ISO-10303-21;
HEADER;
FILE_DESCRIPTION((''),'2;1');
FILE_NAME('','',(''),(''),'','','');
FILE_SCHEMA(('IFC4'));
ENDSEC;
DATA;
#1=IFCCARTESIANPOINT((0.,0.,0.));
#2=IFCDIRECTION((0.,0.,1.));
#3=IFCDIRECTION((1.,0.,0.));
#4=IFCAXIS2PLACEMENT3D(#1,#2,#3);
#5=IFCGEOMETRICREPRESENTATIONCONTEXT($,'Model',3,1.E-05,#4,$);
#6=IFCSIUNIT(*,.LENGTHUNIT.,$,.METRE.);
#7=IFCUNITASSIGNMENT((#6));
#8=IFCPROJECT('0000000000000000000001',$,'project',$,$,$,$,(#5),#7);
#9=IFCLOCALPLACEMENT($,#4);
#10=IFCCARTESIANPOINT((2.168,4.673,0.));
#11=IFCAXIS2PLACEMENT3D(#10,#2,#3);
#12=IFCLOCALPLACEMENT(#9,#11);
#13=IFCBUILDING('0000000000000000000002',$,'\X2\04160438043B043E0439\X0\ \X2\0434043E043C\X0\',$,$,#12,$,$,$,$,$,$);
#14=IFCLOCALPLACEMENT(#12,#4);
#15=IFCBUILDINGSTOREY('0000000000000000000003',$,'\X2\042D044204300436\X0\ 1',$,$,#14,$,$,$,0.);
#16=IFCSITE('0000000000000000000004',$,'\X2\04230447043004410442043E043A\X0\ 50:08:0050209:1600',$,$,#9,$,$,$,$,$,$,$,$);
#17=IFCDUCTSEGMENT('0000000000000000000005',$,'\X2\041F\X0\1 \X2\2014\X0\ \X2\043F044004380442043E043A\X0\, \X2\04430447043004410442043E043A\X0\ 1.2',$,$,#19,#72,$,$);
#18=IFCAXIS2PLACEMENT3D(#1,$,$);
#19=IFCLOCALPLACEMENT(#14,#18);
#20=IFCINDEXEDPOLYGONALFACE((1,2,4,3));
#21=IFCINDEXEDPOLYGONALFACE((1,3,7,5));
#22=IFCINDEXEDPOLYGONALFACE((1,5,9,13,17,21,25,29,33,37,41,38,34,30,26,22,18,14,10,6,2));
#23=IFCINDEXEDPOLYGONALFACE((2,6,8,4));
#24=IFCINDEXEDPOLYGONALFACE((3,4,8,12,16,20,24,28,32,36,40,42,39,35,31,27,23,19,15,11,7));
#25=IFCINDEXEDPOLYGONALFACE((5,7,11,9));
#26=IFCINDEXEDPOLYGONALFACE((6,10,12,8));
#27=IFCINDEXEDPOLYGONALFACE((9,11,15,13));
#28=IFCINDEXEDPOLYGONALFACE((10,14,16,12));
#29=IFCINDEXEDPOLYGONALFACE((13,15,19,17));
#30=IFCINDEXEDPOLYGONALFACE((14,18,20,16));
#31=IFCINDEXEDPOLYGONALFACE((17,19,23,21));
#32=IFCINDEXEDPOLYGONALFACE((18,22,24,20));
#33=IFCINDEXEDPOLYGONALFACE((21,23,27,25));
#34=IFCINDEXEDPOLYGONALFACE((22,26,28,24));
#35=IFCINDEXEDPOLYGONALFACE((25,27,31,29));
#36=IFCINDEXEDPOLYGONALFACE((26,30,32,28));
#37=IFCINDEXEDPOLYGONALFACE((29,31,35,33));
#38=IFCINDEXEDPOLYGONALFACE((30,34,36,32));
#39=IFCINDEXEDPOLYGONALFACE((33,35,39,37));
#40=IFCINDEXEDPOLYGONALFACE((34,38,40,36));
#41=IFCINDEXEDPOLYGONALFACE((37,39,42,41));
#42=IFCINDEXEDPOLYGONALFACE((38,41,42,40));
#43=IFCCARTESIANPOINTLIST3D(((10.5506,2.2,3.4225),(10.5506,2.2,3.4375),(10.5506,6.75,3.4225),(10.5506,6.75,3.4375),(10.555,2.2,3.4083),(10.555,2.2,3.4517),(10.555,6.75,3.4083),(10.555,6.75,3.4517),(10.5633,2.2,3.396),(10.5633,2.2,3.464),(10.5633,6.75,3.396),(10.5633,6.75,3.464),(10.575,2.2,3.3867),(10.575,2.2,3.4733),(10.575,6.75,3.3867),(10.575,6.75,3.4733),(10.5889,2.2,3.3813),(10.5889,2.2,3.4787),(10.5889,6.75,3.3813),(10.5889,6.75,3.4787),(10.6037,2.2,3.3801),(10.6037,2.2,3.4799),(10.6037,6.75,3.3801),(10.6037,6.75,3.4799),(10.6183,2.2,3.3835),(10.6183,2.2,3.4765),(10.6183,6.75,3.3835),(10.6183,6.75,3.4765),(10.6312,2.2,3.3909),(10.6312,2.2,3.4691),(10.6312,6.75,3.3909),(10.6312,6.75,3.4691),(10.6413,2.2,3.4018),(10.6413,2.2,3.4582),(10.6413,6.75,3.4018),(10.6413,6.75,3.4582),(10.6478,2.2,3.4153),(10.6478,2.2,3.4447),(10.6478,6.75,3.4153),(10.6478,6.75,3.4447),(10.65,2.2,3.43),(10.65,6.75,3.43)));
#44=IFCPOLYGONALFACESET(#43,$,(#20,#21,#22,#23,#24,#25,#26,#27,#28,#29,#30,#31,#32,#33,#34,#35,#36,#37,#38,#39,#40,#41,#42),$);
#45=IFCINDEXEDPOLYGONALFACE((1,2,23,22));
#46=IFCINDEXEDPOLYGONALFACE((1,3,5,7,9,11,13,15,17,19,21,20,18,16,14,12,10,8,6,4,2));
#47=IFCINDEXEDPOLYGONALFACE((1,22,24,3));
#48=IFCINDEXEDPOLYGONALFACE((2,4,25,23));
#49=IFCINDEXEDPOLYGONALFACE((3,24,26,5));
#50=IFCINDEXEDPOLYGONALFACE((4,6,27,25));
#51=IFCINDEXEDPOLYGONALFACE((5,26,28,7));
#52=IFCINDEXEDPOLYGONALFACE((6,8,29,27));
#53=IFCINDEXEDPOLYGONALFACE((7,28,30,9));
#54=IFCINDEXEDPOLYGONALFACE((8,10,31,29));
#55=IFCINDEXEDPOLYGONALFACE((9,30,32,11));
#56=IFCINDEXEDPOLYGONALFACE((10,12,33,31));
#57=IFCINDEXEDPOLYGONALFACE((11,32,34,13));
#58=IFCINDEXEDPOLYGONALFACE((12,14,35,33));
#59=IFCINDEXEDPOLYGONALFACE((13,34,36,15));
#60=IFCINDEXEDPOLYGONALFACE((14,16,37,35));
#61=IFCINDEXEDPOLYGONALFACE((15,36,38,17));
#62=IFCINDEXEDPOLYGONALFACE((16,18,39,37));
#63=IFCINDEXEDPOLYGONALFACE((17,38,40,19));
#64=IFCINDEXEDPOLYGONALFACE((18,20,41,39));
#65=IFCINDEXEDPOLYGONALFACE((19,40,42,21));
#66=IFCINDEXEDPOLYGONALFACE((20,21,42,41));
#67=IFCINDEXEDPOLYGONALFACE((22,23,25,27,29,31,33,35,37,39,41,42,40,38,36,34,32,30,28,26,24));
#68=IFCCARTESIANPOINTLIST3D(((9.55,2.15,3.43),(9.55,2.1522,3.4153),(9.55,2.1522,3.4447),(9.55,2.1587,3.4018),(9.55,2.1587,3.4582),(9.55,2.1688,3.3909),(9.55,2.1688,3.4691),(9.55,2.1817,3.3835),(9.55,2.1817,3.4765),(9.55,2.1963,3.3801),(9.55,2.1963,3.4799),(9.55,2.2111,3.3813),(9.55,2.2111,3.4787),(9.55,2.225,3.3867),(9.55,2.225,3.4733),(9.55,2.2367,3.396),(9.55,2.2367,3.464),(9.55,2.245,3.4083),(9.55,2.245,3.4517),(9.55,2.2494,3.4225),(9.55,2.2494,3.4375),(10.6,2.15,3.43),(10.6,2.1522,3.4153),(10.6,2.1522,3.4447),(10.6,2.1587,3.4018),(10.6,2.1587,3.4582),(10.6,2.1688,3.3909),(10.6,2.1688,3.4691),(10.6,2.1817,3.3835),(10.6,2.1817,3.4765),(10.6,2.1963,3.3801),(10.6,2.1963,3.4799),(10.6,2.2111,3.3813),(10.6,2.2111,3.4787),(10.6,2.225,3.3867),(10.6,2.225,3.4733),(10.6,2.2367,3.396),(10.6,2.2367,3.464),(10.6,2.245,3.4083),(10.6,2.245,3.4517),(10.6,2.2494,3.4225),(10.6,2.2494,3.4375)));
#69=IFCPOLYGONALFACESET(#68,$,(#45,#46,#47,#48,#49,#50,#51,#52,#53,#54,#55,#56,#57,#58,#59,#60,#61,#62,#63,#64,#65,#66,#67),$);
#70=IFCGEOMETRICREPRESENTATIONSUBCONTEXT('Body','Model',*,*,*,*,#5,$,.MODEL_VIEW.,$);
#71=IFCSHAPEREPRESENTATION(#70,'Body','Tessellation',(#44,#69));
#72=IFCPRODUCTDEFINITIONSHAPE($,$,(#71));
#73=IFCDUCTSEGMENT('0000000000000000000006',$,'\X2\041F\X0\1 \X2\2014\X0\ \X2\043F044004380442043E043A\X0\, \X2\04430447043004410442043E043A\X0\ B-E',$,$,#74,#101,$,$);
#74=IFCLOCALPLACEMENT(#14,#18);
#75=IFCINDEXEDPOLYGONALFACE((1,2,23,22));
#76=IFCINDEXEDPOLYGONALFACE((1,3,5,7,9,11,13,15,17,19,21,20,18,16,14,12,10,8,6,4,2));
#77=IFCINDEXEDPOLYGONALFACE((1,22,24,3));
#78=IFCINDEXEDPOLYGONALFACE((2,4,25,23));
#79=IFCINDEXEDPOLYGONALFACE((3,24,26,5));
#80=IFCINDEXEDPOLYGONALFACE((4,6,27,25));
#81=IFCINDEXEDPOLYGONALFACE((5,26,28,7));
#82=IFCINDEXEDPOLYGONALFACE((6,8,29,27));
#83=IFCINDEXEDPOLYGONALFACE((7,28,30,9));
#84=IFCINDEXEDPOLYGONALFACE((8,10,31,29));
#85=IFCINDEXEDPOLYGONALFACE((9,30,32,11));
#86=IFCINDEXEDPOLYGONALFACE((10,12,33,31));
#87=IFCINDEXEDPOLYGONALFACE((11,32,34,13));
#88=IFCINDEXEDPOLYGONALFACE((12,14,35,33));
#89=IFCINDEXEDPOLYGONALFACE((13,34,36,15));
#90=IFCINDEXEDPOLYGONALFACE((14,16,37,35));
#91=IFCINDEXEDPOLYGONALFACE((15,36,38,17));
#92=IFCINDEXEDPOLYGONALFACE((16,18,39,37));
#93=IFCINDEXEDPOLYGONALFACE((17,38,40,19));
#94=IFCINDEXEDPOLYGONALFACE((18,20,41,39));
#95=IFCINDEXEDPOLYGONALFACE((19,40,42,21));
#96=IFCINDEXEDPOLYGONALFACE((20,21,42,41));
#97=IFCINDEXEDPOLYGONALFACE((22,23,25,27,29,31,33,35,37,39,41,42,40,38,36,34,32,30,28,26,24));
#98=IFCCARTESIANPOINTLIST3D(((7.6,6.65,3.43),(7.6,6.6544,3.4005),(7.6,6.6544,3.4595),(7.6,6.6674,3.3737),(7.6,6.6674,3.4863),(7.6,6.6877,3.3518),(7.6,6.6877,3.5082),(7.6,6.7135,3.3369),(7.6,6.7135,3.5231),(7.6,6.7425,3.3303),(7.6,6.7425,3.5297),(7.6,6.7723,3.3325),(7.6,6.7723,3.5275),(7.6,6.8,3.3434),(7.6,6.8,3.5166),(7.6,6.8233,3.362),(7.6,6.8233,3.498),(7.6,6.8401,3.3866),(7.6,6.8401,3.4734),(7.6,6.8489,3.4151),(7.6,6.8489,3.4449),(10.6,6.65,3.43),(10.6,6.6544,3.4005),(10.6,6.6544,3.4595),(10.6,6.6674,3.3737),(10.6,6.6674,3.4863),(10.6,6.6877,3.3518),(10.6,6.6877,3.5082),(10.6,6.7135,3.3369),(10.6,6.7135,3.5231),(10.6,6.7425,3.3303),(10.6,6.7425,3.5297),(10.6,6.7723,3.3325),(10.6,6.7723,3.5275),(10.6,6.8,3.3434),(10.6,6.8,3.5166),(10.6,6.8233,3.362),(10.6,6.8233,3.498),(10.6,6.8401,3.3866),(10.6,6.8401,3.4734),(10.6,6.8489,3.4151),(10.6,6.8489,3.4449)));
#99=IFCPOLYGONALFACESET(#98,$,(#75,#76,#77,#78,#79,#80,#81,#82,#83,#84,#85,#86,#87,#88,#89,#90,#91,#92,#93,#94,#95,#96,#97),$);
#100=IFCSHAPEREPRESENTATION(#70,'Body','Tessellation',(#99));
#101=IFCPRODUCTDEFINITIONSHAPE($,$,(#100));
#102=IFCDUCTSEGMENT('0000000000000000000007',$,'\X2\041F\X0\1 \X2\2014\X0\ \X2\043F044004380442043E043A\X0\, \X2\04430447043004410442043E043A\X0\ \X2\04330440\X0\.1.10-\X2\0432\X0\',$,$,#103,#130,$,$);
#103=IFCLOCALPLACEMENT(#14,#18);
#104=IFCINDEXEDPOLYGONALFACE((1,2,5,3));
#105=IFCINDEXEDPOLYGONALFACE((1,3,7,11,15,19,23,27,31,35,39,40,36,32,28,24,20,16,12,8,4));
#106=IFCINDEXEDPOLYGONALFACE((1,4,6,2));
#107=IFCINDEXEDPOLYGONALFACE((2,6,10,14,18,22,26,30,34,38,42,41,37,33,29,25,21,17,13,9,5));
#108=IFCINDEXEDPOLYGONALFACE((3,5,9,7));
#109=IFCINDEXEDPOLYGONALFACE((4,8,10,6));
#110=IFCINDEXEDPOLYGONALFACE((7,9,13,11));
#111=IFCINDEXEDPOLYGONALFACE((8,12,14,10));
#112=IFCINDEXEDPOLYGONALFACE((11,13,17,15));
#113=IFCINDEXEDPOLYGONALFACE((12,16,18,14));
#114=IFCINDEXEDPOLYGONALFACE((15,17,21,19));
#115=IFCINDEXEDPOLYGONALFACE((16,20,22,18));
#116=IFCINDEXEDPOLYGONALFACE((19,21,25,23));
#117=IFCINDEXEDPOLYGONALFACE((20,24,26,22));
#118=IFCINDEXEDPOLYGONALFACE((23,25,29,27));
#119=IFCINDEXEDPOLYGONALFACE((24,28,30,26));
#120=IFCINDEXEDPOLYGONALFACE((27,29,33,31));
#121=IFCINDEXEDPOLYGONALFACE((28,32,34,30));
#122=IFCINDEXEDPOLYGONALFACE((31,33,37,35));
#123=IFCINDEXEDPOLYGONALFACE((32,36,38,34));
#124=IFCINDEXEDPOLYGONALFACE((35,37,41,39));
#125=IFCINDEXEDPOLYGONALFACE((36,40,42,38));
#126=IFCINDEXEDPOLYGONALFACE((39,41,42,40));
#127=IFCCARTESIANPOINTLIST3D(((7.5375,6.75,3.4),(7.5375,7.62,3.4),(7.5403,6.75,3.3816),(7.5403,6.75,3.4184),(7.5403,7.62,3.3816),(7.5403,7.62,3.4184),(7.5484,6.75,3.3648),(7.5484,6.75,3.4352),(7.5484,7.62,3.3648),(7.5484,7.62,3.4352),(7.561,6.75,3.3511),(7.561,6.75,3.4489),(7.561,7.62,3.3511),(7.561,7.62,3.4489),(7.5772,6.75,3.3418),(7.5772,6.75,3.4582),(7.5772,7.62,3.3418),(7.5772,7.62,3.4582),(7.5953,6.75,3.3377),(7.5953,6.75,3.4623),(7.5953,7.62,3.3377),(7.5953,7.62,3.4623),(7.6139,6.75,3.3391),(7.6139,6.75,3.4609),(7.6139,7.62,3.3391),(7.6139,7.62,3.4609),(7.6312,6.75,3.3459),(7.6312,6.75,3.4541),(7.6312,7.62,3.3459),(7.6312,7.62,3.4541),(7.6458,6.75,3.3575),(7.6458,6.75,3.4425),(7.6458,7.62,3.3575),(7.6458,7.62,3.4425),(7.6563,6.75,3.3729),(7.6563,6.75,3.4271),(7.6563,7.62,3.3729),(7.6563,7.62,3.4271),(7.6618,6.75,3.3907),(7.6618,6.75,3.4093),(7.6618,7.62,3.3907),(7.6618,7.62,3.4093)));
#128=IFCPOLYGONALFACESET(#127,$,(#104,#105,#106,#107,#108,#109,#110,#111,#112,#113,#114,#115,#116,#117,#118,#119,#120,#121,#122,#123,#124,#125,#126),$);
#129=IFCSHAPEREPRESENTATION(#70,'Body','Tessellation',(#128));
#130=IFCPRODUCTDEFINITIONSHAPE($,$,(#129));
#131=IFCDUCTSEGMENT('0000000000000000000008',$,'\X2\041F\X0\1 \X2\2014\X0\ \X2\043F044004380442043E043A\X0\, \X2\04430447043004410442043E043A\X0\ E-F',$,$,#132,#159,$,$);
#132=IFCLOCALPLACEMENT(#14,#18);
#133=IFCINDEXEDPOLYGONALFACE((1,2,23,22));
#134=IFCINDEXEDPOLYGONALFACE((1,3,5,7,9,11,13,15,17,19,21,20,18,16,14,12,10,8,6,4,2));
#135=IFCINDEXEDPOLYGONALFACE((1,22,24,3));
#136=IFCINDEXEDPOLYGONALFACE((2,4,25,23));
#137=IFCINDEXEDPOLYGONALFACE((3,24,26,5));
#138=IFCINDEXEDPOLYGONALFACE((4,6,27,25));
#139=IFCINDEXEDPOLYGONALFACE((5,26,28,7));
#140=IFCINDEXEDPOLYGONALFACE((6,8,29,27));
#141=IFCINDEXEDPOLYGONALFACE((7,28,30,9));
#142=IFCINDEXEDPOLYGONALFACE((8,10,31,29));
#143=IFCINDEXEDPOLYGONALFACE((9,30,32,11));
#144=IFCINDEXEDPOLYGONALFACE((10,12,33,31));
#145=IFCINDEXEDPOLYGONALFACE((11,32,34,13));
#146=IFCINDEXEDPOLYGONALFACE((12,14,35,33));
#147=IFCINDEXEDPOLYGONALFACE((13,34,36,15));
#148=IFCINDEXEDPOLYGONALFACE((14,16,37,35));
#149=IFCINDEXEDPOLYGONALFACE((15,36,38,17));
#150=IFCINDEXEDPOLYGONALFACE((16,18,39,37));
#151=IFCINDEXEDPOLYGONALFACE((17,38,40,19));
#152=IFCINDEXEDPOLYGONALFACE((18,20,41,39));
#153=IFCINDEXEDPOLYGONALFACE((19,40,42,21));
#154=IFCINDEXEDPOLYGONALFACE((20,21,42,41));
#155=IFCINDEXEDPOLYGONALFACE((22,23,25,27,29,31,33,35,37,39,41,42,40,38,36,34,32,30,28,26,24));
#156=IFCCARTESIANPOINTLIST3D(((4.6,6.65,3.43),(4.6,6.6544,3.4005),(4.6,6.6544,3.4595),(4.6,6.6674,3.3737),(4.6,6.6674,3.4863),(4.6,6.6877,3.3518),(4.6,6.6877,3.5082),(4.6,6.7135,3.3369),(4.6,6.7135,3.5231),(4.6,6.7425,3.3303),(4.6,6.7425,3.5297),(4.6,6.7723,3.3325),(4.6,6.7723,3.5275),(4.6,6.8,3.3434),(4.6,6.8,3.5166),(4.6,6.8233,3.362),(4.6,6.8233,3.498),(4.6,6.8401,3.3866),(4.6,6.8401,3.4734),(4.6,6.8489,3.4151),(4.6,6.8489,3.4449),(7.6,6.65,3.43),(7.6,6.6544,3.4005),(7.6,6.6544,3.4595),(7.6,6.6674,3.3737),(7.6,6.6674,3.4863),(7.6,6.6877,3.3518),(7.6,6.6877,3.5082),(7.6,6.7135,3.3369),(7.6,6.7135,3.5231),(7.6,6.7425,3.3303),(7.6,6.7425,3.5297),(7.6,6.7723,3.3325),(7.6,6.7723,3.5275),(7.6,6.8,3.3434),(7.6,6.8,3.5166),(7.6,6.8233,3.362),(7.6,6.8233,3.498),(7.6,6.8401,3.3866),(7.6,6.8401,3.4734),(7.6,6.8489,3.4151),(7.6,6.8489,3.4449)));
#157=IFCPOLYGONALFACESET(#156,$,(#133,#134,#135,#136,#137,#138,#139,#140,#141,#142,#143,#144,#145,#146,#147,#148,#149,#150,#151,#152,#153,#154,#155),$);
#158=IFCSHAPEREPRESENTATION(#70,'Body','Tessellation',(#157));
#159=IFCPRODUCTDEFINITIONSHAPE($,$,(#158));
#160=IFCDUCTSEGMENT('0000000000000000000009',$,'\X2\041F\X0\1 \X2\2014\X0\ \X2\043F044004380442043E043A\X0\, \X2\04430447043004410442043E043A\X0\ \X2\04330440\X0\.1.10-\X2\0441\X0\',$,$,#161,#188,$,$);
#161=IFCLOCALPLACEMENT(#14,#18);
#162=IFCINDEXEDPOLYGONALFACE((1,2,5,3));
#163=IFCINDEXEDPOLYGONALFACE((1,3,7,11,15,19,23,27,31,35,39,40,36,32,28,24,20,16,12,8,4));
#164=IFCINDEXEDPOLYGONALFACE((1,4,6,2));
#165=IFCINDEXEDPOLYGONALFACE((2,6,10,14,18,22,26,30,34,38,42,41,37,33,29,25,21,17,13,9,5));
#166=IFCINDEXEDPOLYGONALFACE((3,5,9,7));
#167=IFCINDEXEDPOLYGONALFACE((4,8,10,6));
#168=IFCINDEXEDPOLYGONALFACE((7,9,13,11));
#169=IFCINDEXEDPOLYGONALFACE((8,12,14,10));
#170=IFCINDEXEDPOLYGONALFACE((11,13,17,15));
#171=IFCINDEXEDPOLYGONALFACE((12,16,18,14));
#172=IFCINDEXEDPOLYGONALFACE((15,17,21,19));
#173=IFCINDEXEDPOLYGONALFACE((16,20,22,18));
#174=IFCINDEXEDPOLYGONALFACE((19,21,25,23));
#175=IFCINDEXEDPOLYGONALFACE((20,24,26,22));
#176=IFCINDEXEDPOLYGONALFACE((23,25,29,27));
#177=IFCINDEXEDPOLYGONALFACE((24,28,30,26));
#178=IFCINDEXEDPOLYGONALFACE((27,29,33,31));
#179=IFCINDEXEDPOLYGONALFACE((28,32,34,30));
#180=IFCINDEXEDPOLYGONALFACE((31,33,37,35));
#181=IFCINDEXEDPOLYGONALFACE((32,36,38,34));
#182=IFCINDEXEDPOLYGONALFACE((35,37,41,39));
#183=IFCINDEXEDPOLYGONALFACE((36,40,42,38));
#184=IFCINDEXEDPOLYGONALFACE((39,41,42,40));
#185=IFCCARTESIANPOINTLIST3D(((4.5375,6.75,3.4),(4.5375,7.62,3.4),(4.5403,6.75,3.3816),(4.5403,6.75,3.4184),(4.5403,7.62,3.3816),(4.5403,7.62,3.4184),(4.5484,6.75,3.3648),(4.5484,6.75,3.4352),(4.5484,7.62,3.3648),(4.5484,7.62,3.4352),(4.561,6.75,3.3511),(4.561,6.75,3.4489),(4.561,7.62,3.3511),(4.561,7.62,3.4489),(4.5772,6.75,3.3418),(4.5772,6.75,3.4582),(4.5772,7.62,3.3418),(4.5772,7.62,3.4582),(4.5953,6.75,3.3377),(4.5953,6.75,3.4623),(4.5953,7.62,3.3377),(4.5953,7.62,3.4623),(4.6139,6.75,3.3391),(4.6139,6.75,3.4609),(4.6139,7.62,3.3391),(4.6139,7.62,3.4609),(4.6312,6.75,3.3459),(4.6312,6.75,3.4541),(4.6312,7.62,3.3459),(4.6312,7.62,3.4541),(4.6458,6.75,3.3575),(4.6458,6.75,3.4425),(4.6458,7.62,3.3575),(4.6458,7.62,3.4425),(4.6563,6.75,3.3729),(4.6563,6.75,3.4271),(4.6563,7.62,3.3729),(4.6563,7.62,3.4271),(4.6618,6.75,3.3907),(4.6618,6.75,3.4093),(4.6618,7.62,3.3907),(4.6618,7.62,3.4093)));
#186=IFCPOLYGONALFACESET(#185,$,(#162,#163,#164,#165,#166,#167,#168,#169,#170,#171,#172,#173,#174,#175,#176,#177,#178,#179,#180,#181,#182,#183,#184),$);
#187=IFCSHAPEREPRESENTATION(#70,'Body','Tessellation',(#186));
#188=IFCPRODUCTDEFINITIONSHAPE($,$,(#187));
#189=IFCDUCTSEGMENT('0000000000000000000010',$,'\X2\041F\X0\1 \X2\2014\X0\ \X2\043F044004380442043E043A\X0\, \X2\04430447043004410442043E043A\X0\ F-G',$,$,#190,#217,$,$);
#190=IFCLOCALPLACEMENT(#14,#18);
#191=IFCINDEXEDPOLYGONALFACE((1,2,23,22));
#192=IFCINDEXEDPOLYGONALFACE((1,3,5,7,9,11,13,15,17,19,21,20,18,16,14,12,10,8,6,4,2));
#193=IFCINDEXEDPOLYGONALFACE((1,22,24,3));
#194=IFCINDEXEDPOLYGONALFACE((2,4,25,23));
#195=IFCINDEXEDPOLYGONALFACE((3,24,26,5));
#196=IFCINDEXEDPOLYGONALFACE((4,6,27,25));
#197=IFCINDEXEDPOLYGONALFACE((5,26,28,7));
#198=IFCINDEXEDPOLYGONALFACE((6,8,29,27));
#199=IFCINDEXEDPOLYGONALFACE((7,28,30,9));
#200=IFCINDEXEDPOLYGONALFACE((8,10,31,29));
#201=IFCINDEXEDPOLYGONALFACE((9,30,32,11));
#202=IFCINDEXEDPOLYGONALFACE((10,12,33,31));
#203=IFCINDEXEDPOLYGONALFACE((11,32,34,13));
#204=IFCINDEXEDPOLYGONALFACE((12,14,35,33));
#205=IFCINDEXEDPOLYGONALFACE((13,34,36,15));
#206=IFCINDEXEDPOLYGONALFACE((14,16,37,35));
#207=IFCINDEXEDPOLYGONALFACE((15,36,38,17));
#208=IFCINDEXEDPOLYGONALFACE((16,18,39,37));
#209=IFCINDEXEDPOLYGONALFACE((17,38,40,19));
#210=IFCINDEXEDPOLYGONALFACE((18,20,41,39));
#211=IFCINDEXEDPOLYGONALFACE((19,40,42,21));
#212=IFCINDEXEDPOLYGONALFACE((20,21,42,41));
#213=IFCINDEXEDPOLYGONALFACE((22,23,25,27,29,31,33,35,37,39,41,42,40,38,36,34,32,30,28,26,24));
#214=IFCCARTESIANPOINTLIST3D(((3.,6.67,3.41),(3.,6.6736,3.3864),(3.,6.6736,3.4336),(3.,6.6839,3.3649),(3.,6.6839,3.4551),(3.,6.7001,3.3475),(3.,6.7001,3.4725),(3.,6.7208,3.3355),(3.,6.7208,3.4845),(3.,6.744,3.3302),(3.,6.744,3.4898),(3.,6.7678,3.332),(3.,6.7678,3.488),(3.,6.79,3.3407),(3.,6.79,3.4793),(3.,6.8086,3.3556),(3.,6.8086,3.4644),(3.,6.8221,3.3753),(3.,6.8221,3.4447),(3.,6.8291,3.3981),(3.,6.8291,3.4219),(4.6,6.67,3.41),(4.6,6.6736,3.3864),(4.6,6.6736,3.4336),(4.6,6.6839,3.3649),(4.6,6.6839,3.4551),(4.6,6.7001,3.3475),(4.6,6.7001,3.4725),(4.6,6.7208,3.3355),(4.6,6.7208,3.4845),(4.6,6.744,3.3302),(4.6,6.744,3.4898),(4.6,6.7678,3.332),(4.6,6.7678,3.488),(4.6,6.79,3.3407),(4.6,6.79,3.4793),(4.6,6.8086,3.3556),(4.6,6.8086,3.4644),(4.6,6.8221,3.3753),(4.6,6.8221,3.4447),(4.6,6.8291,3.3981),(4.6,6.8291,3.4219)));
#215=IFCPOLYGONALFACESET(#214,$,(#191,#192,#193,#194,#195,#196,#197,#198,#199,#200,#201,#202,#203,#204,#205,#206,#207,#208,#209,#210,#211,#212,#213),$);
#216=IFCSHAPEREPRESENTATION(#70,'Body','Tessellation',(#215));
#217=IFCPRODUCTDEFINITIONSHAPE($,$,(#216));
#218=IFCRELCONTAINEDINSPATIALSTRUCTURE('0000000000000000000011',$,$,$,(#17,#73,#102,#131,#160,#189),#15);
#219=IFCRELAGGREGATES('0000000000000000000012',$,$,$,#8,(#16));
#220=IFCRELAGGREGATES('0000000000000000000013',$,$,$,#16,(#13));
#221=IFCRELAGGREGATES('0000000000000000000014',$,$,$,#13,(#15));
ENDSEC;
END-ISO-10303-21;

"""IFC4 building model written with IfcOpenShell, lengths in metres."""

from ifc_helpers import new_model, si_unit, frame, origin_with_axes, origin_2d, place, context, subcontext, project, spatial, circle, extrude, element, save


model = new_model("IFC4")

# Units and contexts
model_context = context("Model", 3, precision=1e-05, world=origin_with_axes())
body_context = subcontext(model_context, "Body", "Model", "MODEL_VIEW")
ifc_project = project(units=[si_unit("LENGTHUNIT", "METRE")], contexts=[model_context])

# Site, building, storey
site_placement = place(None, origin_with_axes())
site = spatial("IfcSite", under=ifc_project, at=site_placement, Name="Участок 50:08:0050209:1600")
building_placement = place(site_placement, frame((2.168, 4.673, 0.0), z_axis=(0.0, 0.0, 1.0), x_axis=(1.0, 0.0, 0.0)))
building = spatial("IfcBuilding", under=site, at=building_placement, Name="Жилой дом")
storey_placement = place(building_placement, origin_with_axes())
storey = spatial("IfcBuildingStorey", under=building, at=storey_placement, Name="Этаж 1", Elevation=0.0)

# Duct segments
duct_segment_1_placement = place(storey_placement, origin_with_axes())
element("IfcDuctSegment", 1, at=duct_segment_1_placement, inside=storey, Name="П1 — приток, участок 1.2", context=body_context, shape_type="SweptSolid", body=[
    extrude(circle(Radius=0.05, at=origin_2d()), frame((10.6, 6.75, 3.43), z_axis=(0.0, -1.0, 0.0), x_axis=(1.0, 0.0, 0.0)), (0.0, 0.0, 1.0), 4.55),
    extrude(circle(Radius=0.05, at=origin_2d()), frame((10.6, 2.2, 3.43), z_axis=(-1.0, 0.0, 0.0), x_axis=(0.0, -1.0, 0.0)), (0.0, 0.0, 1.0), 1.05),
])
duct_segment_2_placement = place(storey_placement, origin_with_axes())
element("IfcDuctSegment", 2, at=duct_segment_2_placement, inside=storey, Name="П1 — приток, участок B-E", context=body_context, shape_type="SweptSolid", body=[
    extrude(circle(Radius=0.1, at=origin_2d()), frame((10.6, 6.75, 3.43), z_axis=(-1.0, 0.0, 0.0), x_axis=(0.0, -1.0, 0.0)), (0.0, 0.0, 1.0), 3.0),
])
duct_segment_3_placement = place(storey_placement, origin_with_axes())
element("IfcDuctSegment", 3, at=duct_segment_3_placement, inside=storey, Name="П1 — приток, участок гр.1.10-в", context=body_context, shape_type="SweptSolid", body=[
    extrude(circle(Radius=0.0625, at=origin_2d()), frame((7.6, 6.75, 3.4), z_axis=(0.0, 1.0, 0.0), x_axis=(-1.0, 0.0, 0.0)), (0.0, 0.0, 1.0), 0.87),
])
duct_segment_4_placement = place(storey_placement, origin_with_axes())
element("IfcDuctSegment", 4, at=duct_segment_4_placement, inside=storey, Name="П1 — приток, участок E-F", context=body_context, shape_type="SweptSolid", body=[
    extrude(circle(Radius=0.1, at=origin_2d()), frame((7.6, 6.75, 3.43), z_axis=(-1.0, 0.0, 0.0), x_axis=(0.0, -1.0, 0.0)), (0.0, 0.0, 1.0), 3.0),
])
duct_segment_5_placement = place(storey_placement, origin_with_axes())
element("IfcDuctSegment", 5, at=duct_segment_5_placement, inside=storey, Name="П1 — приток, участок гр.1.10-с", context=body_context, shape_type="SweptSolid", body=[
    extrude(circle(Radius=0.0625, at=origin_2d()), frame((4.6, 6.75, 3.4), z_axis=(0.0, 1.0, 0.0), x_axis=(-1.0, 0.0, 0.0)), (0.0, 0.0, 1.0), 0.87),
])
duct_segment_6_placement = place(storey_placement, origin_with_axes())
element("IfcDuctSegment", 6, at=duct_segment_6_placement, inside=storey, Name="П1 — приток, участок F-G", context=body_context, shape_type="SweptSolid", body=[
    extrude(circle(Radius=0.08, at=origin_2d()), frame((4.6, 6.75, 3.41), z_axis=(-1.0, 0.0, 0.0), x_axis=(0.0, -1.0, 0.0)), (0.0, 0.0, 1.0), 1.6),
])

save(model, "model.ifc")
